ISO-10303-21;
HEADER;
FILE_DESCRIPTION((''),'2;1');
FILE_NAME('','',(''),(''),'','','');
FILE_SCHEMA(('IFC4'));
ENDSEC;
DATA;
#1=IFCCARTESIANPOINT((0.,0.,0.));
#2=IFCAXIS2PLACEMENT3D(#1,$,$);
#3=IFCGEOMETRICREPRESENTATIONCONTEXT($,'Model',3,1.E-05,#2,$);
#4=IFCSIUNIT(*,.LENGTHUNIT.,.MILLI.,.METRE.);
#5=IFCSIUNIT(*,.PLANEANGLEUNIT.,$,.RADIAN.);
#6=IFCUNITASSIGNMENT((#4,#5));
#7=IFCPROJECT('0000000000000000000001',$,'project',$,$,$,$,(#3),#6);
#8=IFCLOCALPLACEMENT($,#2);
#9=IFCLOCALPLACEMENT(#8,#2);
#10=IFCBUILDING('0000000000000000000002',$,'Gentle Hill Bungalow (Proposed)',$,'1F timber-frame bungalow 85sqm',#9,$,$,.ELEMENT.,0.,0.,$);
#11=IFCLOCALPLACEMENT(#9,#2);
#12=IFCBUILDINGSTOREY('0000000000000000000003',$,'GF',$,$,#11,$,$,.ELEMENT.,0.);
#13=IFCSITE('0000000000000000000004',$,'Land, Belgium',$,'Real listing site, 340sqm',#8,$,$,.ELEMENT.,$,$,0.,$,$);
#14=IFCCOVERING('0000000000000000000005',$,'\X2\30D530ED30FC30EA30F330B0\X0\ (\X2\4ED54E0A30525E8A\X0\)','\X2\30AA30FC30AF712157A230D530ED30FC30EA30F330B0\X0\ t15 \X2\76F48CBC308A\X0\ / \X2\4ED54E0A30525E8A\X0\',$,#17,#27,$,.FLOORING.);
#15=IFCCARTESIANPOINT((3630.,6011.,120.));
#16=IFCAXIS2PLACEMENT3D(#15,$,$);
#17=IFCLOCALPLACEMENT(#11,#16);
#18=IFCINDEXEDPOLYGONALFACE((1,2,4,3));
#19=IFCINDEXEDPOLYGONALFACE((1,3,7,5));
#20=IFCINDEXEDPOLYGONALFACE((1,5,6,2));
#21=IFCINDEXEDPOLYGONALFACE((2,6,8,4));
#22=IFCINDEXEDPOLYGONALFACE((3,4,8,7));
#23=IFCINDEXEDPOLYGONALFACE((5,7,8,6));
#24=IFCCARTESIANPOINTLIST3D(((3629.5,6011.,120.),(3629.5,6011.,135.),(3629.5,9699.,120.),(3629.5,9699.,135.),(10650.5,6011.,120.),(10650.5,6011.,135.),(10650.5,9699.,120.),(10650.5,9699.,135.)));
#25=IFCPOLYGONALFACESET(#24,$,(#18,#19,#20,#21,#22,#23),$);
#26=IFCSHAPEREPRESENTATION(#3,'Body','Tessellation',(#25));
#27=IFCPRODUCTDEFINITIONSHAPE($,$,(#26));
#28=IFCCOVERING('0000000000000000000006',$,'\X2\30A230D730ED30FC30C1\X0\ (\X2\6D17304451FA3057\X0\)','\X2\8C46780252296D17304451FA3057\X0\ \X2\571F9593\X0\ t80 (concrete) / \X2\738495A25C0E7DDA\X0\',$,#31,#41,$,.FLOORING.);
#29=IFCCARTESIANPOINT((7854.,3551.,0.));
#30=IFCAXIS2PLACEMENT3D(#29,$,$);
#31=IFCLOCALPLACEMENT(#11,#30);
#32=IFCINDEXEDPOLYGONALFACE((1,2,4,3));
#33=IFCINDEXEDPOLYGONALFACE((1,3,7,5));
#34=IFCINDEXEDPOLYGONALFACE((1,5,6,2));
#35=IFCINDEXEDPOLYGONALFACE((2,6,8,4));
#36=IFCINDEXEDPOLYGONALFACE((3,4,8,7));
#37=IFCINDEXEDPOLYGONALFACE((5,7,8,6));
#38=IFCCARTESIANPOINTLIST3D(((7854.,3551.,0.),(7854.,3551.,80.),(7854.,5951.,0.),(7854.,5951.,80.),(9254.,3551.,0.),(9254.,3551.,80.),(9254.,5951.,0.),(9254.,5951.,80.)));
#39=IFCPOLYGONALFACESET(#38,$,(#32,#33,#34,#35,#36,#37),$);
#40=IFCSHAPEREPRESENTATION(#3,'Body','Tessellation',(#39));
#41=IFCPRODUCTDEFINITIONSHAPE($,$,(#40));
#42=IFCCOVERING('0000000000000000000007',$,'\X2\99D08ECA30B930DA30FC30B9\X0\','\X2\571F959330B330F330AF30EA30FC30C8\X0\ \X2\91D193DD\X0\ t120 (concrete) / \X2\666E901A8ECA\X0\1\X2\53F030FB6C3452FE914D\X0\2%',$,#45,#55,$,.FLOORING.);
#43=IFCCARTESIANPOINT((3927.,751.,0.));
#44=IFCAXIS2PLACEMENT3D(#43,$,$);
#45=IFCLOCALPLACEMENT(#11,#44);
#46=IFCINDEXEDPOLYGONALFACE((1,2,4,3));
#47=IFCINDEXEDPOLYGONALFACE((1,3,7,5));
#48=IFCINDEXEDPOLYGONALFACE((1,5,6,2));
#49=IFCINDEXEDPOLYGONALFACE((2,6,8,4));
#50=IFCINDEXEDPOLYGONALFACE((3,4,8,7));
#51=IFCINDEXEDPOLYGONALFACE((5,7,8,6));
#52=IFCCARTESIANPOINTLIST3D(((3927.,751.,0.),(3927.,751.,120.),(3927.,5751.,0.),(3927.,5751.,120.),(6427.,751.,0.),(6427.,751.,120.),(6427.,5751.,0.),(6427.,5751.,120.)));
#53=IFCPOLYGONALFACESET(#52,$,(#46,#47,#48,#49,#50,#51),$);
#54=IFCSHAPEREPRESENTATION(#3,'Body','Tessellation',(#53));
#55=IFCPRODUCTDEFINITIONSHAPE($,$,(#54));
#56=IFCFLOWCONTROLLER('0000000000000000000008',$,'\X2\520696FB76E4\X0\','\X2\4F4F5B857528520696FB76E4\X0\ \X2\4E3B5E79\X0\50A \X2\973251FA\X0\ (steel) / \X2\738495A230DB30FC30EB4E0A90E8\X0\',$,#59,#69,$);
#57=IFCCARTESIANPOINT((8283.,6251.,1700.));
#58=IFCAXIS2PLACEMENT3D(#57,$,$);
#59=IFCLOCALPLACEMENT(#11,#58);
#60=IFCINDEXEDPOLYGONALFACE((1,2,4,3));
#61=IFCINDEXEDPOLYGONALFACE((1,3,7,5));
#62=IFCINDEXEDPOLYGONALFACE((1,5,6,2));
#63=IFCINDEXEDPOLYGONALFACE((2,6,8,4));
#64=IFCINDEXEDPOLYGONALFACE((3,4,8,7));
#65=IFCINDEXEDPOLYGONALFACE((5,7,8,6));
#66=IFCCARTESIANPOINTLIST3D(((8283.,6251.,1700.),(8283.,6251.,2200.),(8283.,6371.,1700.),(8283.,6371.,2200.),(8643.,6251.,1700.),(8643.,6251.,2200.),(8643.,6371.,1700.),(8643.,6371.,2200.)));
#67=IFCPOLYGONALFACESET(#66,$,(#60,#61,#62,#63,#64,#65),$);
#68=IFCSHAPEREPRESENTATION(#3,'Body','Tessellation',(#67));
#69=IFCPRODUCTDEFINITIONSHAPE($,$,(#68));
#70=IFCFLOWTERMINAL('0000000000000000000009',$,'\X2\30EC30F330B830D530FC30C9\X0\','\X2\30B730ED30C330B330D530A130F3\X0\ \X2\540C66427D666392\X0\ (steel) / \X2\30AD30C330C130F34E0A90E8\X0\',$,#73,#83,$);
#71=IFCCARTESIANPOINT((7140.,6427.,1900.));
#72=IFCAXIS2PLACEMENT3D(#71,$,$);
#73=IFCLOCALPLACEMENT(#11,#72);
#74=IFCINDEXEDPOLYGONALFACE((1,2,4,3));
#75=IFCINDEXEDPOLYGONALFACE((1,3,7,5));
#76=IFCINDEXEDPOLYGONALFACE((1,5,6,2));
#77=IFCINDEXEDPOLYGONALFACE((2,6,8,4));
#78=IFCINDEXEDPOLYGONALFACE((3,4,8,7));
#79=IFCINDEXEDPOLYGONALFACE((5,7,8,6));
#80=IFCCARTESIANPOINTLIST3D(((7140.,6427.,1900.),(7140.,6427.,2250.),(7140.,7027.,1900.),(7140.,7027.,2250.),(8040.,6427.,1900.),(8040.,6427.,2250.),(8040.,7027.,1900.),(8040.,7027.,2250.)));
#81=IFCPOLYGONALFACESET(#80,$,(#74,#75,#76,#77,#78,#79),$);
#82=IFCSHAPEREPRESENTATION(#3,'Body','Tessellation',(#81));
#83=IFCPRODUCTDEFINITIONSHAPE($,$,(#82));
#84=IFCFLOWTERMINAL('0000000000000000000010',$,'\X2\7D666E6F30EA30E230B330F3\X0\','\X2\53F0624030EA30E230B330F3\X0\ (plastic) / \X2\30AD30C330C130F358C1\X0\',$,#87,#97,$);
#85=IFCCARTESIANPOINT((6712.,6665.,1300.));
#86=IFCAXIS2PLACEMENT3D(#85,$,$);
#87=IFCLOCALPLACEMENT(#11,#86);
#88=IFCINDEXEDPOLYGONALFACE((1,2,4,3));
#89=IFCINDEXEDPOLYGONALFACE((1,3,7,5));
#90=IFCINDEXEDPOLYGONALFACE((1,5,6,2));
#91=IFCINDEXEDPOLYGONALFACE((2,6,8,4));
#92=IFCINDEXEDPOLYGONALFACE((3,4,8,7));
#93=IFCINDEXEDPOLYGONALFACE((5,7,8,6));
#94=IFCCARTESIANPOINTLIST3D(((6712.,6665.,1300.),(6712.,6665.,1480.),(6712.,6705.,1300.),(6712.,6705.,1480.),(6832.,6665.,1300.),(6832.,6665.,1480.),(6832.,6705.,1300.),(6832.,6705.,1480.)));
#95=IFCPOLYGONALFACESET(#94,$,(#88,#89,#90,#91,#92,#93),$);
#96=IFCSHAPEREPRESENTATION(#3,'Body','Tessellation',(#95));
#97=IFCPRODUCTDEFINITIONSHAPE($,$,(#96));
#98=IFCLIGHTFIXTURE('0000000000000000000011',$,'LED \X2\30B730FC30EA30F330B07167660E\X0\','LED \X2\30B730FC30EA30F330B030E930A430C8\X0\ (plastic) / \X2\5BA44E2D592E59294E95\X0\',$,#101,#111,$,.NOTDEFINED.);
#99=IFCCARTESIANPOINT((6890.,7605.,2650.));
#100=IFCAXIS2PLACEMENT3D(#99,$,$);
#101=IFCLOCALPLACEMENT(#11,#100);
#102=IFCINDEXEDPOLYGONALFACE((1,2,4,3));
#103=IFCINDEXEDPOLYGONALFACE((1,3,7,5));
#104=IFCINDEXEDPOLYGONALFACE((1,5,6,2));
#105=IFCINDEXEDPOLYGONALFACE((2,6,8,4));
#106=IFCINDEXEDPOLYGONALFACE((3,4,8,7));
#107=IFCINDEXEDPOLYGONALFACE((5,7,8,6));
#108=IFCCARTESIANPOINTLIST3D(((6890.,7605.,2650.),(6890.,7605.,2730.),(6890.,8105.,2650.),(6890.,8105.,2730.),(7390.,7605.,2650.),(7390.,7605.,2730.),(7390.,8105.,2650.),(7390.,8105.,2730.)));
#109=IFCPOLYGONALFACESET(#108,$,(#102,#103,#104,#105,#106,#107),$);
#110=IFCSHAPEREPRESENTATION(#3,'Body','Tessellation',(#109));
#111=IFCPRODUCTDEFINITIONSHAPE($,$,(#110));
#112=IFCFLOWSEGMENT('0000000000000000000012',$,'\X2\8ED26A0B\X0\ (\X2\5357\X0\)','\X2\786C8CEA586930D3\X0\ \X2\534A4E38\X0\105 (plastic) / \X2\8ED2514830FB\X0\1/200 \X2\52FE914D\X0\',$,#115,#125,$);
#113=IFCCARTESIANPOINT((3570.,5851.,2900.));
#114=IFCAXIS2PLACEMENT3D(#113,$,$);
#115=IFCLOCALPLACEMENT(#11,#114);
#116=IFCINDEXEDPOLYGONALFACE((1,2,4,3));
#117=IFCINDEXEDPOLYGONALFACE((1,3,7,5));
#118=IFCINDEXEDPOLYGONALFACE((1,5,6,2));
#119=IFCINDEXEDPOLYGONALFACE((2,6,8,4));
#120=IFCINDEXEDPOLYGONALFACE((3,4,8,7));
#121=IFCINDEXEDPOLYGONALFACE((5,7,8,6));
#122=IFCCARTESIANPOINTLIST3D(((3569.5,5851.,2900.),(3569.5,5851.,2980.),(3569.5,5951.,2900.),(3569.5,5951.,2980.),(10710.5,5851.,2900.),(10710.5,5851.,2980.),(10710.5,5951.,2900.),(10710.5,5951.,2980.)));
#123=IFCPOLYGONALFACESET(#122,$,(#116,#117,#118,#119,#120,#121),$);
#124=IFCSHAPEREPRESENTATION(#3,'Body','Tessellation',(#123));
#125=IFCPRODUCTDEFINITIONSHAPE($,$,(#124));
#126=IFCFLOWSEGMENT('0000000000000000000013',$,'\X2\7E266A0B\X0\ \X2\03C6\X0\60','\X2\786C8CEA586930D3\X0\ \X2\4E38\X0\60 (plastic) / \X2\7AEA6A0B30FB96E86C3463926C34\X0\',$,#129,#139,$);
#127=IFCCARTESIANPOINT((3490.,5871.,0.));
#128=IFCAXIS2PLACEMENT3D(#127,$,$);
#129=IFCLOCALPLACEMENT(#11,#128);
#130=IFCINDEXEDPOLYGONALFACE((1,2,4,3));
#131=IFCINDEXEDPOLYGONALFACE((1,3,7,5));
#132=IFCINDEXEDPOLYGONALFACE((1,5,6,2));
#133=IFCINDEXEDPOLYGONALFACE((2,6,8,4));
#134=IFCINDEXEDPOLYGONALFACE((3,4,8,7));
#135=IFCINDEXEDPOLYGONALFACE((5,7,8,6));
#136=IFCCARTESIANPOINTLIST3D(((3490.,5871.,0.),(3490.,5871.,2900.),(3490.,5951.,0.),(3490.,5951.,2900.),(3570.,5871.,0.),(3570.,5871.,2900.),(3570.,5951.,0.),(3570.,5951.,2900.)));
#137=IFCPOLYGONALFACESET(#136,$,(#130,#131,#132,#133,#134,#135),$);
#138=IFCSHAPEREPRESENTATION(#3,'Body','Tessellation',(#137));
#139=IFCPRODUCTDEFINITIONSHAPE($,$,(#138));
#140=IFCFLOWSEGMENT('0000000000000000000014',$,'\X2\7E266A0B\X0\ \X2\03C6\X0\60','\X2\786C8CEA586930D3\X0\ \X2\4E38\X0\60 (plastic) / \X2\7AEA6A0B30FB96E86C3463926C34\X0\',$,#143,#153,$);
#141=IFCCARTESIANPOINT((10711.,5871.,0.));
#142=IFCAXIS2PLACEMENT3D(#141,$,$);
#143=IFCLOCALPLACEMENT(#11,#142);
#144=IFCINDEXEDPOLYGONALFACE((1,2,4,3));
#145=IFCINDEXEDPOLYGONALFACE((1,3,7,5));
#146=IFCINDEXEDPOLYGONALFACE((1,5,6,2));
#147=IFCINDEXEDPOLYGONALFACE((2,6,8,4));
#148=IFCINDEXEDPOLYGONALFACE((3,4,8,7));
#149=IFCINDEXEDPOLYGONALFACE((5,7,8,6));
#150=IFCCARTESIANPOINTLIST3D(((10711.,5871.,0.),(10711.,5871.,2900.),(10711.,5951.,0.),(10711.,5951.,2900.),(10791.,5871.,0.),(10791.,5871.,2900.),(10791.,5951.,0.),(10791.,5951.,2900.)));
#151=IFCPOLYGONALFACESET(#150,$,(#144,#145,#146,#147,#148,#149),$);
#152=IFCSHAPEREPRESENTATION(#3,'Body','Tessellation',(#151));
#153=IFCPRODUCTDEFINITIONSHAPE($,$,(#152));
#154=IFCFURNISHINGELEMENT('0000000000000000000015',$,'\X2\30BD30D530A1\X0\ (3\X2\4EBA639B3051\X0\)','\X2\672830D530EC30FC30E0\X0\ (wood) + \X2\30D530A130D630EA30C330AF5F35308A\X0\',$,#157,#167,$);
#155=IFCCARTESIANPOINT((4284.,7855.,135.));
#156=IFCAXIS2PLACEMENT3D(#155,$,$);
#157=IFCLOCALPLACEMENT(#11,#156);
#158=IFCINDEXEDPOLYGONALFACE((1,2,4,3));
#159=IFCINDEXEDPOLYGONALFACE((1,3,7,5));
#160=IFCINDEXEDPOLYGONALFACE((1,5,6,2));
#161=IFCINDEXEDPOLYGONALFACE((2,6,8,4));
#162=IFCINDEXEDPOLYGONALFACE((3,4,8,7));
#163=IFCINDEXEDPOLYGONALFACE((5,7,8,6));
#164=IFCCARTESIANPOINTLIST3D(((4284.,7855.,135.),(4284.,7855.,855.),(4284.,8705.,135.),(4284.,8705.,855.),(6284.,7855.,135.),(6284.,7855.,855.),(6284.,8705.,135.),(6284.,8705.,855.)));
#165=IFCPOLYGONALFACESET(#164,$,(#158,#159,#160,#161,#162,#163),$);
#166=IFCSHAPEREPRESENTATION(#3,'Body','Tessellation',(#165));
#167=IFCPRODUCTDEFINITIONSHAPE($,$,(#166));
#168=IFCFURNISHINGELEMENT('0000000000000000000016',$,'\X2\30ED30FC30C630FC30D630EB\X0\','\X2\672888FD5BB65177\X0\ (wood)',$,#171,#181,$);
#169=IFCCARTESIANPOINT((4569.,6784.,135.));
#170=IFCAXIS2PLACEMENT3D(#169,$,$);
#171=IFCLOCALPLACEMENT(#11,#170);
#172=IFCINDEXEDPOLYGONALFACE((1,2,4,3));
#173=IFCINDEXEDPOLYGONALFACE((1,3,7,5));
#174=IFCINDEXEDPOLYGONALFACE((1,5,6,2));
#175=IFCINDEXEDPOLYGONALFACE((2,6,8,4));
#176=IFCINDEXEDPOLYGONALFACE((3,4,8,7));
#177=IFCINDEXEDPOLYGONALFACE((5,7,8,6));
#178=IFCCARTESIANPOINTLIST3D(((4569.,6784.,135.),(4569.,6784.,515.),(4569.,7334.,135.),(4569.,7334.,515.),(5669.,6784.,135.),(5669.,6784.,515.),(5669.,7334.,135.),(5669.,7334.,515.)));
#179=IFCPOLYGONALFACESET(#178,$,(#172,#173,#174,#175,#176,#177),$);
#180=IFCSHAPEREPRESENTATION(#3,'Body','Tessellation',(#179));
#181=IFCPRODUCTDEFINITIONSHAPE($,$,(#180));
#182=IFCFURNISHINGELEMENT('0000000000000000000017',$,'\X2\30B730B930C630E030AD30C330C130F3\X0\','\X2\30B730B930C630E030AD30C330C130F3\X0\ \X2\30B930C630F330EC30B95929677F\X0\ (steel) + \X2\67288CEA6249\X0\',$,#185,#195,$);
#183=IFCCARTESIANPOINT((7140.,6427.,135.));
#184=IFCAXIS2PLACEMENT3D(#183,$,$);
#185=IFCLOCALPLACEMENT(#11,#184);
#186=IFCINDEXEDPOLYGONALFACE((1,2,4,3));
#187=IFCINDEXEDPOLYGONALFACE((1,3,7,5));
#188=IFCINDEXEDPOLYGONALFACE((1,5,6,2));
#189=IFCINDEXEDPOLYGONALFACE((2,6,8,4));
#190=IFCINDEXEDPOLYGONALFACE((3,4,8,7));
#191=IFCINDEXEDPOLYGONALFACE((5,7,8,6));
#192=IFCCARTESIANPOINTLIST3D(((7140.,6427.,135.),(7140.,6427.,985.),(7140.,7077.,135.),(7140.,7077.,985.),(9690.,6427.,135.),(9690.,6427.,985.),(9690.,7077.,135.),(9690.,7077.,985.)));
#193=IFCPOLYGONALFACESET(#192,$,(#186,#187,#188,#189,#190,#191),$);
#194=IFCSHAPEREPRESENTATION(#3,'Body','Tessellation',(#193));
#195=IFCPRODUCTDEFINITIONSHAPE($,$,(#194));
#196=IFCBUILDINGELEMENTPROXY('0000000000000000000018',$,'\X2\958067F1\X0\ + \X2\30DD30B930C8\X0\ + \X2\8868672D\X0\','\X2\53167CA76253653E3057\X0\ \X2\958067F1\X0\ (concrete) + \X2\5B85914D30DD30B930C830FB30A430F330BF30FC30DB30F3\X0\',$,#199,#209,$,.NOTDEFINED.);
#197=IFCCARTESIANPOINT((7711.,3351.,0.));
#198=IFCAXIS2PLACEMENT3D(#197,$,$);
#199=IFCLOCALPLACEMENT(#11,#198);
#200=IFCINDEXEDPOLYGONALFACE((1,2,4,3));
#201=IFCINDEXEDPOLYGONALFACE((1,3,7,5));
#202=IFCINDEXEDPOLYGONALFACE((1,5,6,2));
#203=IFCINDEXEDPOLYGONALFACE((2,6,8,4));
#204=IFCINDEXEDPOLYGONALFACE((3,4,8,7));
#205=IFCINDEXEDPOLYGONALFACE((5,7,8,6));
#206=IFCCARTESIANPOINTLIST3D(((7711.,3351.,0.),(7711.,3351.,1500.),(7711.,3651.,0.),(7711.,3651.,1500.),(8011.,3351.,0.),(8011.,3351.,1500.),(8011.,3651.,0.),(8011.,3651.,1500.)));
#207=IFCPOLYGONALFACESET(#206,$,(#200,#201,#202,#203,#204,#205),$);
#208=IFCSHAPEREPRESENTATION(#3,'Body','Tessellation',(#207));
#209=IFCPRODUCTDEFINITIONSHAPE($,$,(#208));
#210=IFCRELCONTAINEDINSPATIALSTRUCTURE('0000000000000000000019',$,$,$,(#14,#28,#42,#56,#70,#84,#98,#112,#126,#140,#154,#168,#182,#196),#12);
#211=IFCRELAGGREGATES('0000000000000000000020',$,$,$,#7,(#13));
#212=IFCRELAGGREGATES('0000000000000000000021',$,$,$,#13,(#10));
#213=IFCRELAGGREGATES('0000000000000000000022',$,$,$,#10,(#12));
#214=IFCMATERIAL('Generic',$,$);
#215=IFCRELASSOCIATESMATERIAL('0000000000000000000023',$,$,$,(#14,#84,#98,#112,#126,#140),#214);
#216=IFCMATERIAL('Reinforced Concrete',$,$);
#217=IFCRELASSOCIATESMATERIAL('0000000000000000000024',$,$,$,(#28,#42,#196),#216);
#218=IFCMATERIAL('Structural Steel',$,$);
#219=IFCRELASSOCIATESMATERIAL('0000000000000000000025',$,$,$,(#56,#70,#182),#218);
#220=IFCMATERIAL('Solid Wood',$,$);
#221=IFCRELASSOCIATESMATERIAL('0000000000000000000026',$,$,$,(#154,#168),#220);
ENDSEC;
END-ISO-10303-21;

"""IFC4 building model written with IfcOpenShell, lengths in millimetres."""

from ifc_helpers import new_model, si_unit, frame, frame_2d, origin, place, context, project, spatial, rectangle, extrude, material, element, save


model = new_model("IFC4")

# Units and contexts
model_context = context("Model", 3, precision=1e-05, world=origin())
ifc_project = project(units=[si_unit("LENGTHUNIT", "METRE", prefix="MILLI"), si_unit("PLANEANGLEUNIT", "RADIAN")], contexts=[model_context])

# Site, building, storey
site_placement = place(None, origin())
site = spatial("IfcSite", under=ifc_project, at=site_placement, Name="Land, Belgium", ObjectType="Real listing site, 340sqm", CompositionType="ELEMENT", RefElevation=0.0)
building_placement = place(site_placement, origin())
building = spatial("IfcBuilding", under=site, at=building_placement, Name="Gentle Hill Bungalow (Proposed)", ObjectType="1F timber-frame bungalow 85sqm", CompositionType="ELEMENT", ElevationOfRefHeight=0.0, ElevationOfTerrain=0.0)
storey_placement = place(building_placement, origin())
storey = spatial("IfcBuildingStorey", under=building, at=storey_placement, Name="GF", CompositionType="ELEMENT", Elevation=0.0)

# Shared definitions
ifc_material_1 = material(Name="Solid Wood")

# Shared definitions
ifc_material_2 = material(Name="Reinforced Concrete")

# Shared definitions
ifc_material_3 = material(Name="Structural Steel")

# Coverings
ifc_material_4 = material(Name="Generic")
covering_1_placement = place(storey_placement, frame((3630.0, 6011.0, 120.0)))
element("IfcCovering", 1, at=covering_1_placement, inside=storey, material=ifc_material_4, Name="フローリング (仕上げ床)", Description="オーク無垢フローリング t15 直貼り / 仕上げ床", PredefinedType="FLOORING", context=model_context, shape_type="SweptSolid", body=[
    extrude(rectangle(XDim=7021.0, YDim=3688.0, at=frame_2d((3510.0, 1844.0))), frame((3630.0, 6011.0, 120.0)), (0.0, 0.0, 1.0), 15.0),
])
covering_2_placement = place(storey_placement, frame((7854.0, 3551.0, 0.0)))
element("IfcCovering", 2, at=covering_2_placement, inside=storey, material=ifc_material_2, Name="アプローチ (洗い出し)", Description="豆砂利洗い出し 土間 t80 (concrete) / 玄関導線", PredefinedType="FLOORING", context=model_context, shape_type="SweptSolid", body=[
    extrude(rectangle(XDim=1400.0, YDim=2400.0, at=frame_2d((700.0, 1200.0))), frame((7854.0, 3551.0, 0.0)), (0.0, 0.0, 1.0), 80.0),
])
covering_3_placement = place(storey_placement, frame((3927.0, 751.0, 0.0)))
element("IfcCovering", 3, at=covering_3_placement, inside=storey, material=ifc_material_2, Name="駐車スペース", Description="土間コンクリート 金鏝 t120 (concrete) / 普通車1台・水勾配2%", PredefinedType="FLOORING", context=model_context, shape_type="SweptSolid", body=[
    extrude(rectangle(XDim=2500.0, YDim=5000.0, at=frame_2d((1250.0, 2500.0))), frame((3927.0, 751.0, 0.0)), (0.0, 0.0, 1.0), 120.0),
])

# Flow controller
flow_controller_placement = place(storey_placement, frame((8283.0, 6251.0, 1700.0)))
element("IfcFlowController", 4, at=flow_controller_placement, inside=storey, material=ifc_material_3, Name="分電盤", Description="住宅用分電盤 主幹50A 露出 (steel) / 玄関ホール上部", context=model_context, shape_type="SweptSolid", body=[
    extrude(rectangle(XDim=360.0, YDim=120.0, at=frame_2d((180.0, 60.0))), frame((8283.0, 6251.0, 1700.0)), (0.0, 0.0, 1.0), 500.0),
])

# Flow terminals
flow_terminal_1_placement = place(storey_placement, frame((7140.0, 6427.0, 1900.0)))
element("IfcFlowTerminal", 5, at=flow_terminal_1_placement, inside=storey, material=ifc_material_3, Name="レンジフード", Description="シロッコファン 同時給排 (steel) / キッチン上部", context=model_context, shape_type="SweptSolid", body=[
    extrude(rectangle(XDim=900.0, YDim=600.0, at=frame_2d((450.0, 300.0))), frame((7140.0, 6427.0, 1900.0)), (0.0, 0.0, 1.0), 350.0),
])
flow_terminal_2_placement = place(storey_placement, frame((6712.0, 6665.0, 1300.0)))
element("IfcFlowTerminal", 6, at=flow_terminal_2_placement, inside=storey, material=ifc_material_4, Name="給湯リモコン", Description="台所リモコン (plastic) / キッチン壁", context=model_context, shape_type="SweptSolid", body=[
    extrude(rectangle(XDim=120.0, YDim=40.0, at=frame_2d((60.0, 20.0))), frame((6712.0, 6665.0, 1300.0)), (0.0, 0.0, 1.0), 180.0),
])

# Light fixture
light_fixture_placement = place(storey_placement, frame((6890.0, 7605.0, 2650.0)))
element("IfcLightFixture", 7, at=light_fixture_placement, inside=storey, material=ifc_material_4, Name="LED シーリング照明", Description="LED シーリングライト (plastic) / 室中央天井", PredefinedType="NOTDEFINED", context=model_context, shape_type="SweptSolid", body=[
    extrude(rectangle(XDim=500.0, YDim=500.0, at=frame_2d((250.0, 250.0))), frame((6890.0, 7605.0, 2650.0)), (0.0, 0.0, 1.0), 80.0),
])

# Flow segments
flow_segment_1_placement = place(storey_placement, frame((3570.0, 5851.0, 2900.0)))
element("IfcFlowSegment", 8, at=flow_segment_1_placement, inside=storey, material=ifc_material_4, Name="軒樋 (南)", Description="硬質塩ビ 半丸105 (plastic) / 軒先・1/200 勾配", context=model_context, shape_type="SweptSolid", body=[
    extrude(rectangle(XDim=7141.0, YDim=100.0, at=frame_2d((3570.0, 50.0))), frame((3570.0, 5851.0, 2900.0)), (0.0, 0.0, 1.0), 80.0),
])
flow_segment_2_placement = place(storey_placement, frame((3490.0, 5871.0, 0.0)))
element("IfcFlowSegment", 9, at=flow_segment_2_placement, inside=storey, material=ifc_material_4, Name="縦樋 φ60", Description="硬質塩ビ 丸60 (plastic) / 竪樋・雨水排水", context=model_context, shape_type="SweptSolid", body=[
    extrude(rectangle(XDim=80.0, YDim=80.0, at=frame_2d((40.0, 40.0))), frame((3490.0, 5871.0, 0.0)), (0.0, 0.0, 1.0), 2900.0),
])
flow_segment_3_placement = place(storey_placement, frame((10711.0, 5871.0, 0.0)))
element("IfcFlowSegment", 10, at=flow_segment_3_placement, inside=storey, material=ifc_material_4, Name="縦樋 φ60", Description="硬質塩ビ 丸60 (plastic) / 竪樋・雨水排水", context=model_context, shape_type="SweptSolid", body=[
    extrude(rectangle(XDim=80.0, YDim=80.0, at=frame_2d((40.0, 40.0))), frame((10711.0, 5871.0, 0.0)), (0.0, 0.0, 1.0), 2900.0),
])

# Furnishing elements
furnishing_1_placement = place(storey_placement, frame((4284.0, 7855.0, 135.0)))
element("IfcFurnishingElement", 11, at=furnishing_1_placement, inside=storey, material=ifc_material_1, Name="ソファ (3人掛け)", Description="木フレーム (wood) + ファブリック張り", context=model_context, shape_type="SweptSolid", body=[
    extrude(rectangle(XDim=2000.0, YDim=850.0, at=frame_2d((1000.0, 425.0))), frame((4284.0, 7855.0, 135.0)), (0.0, 0.0, 1.0), 720.0),
])
furnishing_2_placement = place(storey_placement, frame((4569.0, 6784.0, 135.0)))
element("IfcFurnishingElement", 12, at=furnishing_2_placement, inside=storey, material=ifc_material_1, Name="ローテーブル", Description="木製家具 (wood)", context=model_context, shape_type="SweptSolid", body=[
    extrude(rectangle(XDim=1100.0, YDim=550.0, at=frame_2d((550.0, 275.0))), frame((4569.0, 6784.0, 135.0)), (0.0, 0.0, 1.0), 380.0),
])
furnishing_3_placement = place(storey_placement, frame((7140.0, 6427.0, 135.0)))
element("IfcFurnishingElement", 13, at=furnishing_3_placement, inside=storey, material=ifc_material_3, Name="システムキッチン", Description="システムキッチン ステンレス天板 (steel) + 木質扉", context=model_context, shape_type="SweptSolid", body=[
    extrude(rectangle(XDim=2550.0, YDim=650.0, at=frame_2d((1275.0, 325.0))), frame((7140.0, 6427.0, 135.0)), (0.0, 0.0, 1.0), 850.0),
])

# Building element proxy
proxy_placement = place(storey_placement, frame((7711.0, 3351.0, 0.0)))
element("IfcBuildingElementProxy", 14, at=proxy_placement, inside=storey, material=ifc_material_2, Name="門柱 + ポスト + 表札", Description="化粧打放し 門柱 (concrete) + 宅配ポスト・インターホン", PredefinedType="NOTDEFINED", context=model_context, shape_type="SweptSolid", body=[
    extrude(rectangle(XDim=300.0, YDim=300.0, at=frame_2d((150.0, 150.0))), frame((7711.0, 3351.0, 0.0)), (0.0, 0.0, 1.0), 1500.0),
])

save(model, "model.ifc")
